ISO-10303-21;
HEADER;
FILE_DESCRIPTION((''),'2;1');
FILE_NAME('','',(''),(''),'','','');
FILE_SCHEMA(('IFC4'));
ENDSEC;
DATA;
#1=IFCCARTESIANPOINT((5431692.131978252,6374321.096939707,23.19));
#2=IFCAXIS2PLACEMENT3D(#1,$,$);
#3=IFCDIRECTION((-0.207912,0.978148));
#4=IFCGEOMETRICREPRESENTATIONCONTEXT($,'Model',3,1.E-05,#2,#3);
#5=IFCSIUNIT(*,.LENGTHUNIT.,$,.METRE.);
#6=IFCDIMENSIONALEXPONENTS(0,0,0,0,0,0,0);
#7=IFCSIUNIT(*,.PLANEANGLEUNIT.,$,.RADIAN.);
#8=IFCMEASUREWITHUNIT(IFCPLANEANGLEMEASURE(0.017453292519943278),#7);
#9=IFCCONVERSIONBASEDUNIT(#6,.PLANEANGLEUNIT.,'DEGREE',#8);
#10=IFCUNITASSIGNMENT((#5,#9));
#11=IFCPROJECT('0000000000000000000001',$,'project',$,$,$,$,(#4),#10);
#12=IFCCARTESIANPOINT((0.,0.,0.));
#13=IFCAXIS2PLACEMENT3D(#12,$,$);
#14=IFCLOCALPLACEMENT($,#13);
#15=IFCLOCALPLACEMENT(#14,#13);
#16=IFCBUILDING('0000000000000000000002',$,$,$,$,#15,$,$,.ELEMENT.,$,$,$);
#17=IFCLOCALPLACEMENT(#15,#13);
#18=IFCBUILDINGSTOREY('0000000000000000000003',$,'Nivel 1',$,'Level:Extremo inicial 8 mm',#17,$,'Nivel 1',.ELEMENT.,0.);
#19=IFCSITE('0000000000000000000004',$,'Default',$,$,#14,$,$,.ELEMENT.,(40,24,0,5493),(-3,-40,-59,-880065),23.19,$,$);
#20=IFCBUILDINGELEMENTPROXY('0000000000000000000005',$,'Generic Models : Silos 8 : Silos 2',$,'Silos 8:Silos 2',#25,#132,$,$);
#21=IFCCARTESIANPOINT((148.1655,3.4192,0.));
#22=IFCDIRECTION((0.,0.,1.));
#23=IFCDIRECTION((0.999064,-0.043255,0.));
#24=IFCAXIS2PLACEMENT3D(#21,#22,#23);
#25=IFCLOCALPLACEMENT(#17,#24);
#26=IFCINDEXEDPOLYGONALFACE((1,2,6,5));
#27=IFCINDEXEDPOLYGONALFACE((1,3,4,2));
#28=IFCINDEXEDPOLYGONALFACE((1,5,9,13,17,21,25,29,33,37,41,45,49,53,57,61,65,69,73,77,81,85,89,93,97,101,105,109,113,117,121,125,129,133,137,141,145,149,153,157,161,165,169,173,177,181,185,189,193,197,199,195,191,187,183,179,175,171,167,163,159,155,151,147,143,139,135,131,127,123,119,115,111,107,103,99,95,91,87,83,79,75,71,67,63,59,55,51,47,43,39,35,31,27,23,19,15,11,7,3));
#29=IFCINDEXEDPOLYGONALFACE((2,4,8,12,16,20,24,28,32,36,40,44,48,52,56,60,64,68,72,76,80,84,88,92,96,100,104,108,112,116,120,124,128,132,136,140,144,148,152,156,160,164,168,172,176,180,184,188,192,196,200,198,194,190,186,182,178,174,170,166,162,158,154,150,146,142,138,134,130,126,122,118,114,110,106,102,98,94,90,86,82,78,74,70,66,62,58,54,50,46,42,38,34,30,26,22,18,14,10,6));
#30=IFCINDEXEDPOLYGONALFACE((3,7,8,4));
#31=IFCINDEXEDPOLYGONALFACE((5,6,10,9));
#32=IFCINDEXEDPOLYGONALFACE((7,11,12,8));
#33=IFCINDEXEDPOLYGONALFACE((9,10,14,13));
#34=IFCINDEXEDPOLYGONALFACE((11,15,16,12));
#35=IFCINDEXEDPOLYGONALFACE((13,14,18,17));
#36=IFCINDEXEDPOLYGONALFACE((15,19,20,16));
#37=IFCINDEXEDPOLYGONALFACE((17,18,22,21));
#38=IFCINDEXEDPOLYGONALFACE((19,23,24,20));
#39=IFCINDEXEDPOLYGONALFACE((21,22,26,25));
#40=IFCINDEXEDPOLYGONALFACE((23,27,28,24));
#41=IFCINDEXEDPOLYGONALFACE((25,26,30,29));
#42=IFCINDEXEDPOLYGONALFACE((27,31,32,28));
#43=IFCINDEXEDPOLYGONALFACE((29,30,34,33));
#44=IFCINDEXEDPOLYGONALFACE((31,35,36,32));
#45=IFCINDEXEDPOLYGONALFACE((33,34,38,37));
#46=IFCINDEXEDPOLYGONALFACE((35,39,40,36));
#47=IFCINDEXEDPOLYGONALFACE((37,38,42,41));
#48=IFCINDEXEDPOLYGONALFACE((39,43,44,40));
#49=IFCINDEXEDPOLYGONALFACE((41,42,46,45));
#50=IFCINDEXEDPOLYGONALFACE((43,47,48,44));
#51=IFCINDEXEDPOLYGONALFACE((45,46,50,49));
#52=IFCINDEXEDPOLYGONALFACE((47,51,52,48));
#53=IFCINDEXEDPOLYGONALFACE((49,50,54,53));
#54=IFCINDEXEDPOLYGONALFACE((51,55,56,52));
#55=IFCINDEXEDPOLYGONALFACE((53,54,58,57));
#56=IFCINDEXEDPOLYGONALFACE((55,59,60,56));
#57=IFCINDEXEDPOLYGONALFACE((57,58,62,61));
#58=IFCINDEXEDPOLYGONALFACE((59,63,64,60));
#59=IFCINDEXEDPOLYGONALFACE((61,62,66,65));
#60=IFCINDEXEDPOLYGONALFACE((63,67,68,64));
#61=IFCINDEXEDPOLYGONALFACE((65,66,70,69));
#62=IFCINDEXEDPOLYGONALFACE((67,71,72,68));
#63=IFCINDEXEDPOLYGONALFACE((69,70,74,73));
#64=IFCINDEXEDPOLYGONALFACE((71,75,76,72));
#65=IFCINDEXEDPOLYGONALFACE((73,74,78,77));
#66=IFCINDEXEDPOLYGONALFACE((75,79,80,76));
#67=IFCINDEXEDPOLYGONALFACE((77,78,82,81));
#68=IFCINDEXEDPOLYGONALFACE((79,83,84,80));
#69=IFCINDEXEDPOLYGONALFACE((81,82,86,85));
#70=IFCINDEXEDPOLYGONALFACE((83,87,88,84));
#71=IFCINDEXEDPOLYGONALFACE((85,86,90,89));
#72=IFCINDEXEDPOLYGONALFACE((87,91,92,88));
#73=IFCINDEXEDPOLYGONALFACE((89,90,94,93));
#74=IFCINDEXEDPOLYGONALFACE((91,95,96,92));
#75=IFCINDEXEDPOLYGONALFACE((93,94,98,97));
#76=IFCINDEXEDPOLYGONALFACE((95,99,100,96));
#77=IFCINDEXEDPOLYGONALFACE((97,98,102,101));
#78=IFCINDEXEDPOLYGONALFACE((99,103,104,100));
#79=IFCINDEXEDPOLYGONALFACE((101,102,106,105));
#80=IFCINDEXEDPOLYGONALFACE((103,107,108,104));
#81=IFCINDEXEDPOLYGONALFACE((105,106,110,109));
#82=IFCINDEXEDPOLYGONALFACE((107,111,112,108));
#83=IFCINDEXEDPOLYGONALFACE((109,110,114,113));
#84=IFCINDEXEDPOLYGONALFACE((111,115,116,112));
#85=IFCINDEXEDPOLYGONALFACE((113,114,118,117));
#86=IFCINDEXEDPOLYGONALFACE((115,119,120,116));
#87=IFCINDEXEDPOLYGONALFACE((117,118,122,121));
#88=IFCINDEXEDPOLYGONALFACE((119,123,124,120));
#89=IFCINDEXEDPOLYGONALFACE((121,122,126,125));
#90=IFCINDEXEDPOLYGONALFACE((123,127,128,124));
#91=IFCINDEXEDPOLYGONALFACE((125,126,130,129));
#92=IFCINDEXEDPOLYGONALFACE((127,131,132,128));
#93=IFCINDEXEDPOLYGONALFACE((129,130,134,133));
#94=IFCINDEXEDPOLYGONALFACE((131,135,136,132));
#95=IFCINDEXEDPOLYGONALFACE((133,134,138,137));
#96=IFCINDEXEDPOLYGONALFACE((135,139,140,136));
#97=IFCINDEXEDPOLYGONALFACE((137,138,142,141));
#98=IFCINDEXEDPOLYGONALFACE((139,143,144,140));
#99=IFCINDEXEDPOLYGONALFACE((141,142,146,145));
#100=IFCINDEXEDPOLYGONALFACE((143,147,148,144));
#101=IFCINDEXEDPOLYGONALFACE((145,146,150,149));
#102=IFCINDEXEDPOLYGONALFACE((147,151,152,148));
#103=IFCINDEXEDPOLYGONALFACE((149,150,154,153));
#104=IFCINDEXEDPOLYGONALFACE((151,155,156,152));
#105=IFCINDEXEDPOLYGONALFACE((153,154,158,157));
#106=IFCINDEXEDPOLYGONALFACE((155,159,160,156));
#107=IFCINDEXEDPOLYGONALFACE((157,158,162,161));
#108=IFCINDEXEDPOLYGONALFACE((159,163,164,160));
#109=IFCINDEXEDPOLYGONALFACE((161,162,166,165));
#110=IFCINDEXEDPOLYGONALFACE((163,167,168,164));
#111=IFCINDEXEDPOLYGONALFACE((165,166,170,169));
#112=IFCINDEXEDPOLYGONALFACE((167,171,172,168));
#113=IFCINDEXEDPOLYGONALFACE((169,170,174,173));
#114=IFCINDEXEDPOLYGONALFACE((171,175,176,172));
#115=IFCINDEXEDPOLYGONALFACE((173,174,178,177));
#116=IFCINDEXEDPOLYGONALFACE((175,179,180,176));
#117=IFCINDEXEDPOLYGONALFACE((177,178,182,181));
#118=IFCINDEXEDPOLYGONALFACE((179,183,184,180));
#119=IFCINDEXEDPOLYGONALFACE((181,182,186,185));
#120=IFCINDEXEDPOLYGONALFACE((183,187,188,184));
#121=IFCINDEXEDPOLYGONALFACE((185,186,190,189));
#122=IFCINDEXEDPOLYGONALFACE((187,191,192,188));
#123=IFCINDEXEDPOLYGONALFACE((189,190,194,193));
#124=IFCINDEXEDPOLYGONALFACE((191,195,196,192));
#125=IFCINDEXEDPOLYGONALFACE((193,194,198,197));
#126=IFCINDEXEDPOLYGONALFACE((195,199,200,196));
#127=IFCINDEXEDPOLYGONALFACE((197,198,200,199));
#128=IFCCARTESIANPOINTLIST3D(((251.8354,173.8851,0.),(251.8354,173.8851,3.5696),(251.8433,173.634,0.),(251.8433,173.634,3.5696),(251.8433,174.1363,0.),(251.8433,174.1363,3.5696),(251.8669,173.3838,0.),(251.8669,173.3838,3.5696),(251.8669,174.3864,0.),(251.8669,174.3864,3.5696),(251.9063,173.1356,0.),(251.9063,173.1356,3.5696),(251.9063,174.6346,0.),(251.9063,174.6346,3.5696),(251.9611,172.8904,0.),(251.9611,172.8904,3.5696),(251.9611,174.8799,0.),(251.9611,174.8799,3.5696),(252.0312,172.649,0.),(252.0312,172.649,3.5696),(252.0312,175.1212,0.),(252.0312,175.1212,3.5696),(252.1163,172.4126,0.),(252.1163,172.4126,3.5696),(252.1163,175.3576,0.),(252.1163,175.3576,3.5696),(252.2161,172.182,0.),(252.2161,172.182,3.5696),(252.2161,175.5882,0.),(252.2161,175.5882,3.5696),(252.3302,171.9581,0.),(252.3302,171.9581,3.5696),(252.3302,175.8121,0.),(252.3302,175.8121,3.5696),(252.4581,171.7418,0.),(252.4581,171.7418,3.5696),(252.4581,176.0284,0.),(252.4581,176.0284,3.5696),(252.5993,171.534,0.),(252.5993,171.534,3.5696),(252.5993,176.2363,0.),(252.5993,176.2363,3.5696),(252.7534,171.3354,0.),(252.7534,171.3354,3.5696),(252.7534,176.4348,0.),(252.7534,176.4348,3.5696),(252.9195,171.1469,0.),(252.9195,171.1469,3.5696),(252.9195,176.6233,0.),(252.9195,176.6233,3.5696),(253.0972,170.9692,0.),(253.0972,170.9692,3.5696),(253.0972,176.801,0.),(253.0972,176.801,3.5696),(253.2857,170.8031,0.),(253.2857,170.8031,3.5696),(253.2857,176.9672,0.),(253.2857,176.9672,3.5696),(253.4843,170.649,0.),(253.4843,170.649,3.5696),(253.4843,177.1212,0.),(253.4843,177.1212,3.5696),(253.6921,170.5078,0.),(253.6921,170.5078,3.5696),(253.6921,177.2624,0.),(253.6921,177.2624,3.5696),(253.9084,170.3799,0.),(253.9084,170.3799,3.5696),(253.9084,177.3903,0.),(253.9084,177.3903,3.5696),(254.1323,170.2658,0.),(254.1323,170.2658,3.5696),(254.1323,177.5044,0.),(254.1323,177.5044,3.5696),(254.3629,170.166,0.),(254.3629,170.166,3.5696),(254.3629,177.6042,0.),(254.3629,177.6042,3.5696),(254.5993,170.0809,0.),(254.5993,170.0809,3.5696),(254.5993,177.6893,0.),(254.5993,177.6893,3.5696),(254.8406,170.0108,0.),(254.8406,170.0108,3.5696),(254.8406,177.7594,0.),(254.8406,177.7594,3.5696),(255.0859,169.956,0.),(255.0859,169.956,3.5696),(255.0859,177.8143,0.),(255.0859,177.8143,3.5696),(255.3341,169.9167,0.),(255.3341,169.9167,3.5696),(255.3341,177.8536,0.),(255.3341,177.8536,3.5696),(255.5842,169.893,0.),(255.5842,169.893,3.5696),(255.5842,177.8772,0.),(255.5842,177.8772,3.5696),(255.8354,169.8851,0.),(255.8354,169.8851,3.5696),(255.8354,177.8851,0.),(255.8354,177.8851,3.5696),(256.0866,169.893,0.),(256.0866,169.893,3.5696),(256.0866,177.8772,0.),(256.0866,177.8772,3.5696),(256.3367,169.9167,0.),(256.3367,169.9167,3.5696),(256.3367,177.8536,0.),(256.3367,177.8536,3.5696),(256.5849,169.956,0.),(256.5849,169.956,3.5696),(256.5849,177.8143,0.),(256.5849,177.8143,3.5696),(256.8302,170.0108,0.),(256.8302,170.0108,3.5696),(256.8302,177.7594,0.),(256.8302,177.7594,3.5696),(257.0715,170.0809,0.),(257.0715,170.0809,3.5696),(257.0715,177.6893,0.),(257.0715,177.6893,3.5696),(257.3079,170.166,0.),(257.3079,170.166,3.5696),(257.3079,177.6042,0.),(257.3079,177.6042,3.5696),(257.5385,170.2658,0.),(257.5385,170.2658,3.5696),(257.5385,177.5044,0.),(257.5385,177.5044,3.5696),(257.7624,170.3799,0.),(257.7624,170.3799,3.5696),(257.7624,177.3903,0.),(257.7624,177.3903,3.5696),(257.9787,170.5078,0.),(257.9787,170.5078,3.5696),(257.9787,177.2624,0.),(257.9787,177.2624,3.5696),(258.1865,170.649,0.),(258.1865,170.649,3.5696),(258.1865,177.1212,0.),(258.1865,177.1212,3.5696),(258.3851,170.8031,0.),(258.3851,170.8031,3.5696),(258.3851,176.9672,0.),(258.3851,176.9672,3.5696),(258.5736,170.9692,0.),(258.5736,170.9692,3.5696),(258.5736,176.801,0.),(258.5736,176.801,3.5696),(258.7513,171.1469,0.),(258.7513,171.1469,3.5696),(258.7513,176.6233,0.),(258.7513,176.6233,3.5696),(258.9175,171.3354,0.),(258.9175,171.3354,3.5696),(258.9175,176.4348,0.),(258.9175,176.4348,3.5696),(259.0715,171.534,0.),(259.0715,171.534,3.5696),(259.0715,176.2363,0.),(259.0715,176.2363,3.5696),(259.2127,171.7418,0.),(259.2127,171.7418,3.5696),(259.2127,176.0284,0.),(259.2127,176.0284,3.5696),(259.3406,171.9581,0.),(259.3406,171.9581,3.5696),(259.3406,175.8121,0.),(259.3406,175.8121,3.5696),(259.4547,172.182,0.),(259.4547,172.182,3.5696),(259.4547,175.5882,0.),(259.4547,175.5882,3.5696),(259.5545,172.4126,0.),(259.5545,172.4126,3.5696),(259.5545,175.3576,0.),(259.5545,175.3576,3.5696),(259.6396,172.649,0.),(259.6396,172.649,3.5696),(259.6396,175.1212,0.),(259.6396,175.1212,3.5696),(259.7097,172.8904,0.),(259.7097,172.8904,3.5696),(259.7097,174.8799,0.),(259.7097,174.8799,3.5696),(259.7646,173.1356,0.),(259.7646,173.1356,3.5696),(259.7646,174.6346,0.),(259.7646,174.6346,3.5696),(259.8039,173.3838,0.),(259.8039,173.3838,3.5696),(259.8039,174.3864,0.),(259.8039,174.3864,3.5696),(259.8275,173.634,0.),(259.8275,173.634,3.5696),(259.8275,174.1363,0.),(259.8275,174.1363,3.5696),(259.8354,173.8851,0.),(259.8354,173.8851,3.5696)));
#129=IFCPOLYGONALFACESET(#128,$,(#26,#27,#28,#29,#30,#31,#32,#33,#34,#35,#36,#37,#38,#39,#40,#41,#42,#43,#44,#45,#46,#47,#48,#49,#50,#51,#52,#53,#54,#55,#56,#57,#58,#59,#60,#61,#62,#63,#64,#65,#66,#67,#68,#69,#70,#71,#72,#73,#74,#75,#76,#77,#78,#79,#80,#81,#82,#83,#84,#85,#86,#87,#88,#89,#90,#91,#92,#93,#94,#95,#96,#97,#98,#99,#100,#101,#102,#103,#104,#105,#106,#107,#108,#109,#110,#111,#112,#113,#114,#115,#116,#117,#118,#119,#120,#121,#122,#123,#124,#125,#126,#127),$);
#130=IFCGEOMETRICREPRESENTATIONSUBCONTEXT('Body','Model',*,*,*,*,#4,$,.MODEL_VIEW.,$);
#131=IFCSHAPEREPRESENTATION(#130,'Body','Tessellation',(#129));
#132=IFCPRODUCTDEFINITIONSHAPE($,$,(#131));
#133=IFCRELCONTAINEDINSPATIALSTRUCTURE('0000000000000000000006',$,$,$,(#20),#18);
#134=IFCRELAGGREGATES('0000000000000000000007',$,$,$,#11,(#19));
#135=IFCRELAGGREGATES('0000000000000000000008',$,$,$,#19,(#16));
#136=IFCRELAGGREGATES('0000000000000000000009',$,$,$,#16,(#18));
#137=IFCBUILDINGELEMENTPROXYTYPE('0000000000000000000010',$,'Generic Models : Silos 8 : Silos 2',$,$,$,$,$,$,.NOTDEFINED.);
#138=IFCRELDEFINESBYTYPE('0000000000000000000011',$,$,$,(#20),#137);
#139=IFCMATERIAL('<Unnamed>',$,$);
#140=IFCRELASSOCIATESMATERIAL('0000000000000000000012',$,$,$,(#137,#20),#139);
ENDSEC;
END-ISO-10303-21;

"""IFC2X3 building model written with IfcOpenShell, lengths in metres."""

from ifc_helpers import new_model, entity, si_unit, converted_unit, direction, frame, origin, origin_2d_with_axis, place, context, subcontext, project, spatial, circle, extrude, source, transform, mapped, material, type_object, type_shapes, element, save


model = new_model("IFC2X3")

# Units and contexts
model_context = context("Model", 3, precision=1e-05, world=frame((5431692.131978252, 6374321.096939707, 23.19)), true_north=direction((-0.207912, 0.978148)))
body_context = subcontext(model_context, "Body", "Model", "MODEL_VIEW")
ifc_project = project(units=[si_unit("LENGTHUNIT", "METRE"), converted_unit("PLANEANGLEUNIT", "DEGREE", entity("IfcPlaneAngleMeasure", 0.017453292519943278), si_unit("PLANEANGLEUNIT", "RADIAN"), dimensions=[0, 0, 0, 0, 0, 0, 0])], contexts=[model_context])

# Site, building, storey
site_placement = place(None, origin())
site = spatial("IfcSite", under=ifc_project, at=site_placement, Name="Default", CompositionType="ELEMENT", RefLatitude=(40, 24, 0, 5493), RefLongitude=(-3, -40, -59, -880065), RefElevation=23.19)
building_placement = place(site_placement, origin())
building = spatial("IfcBuilding", under=site, at=building_placement, CompositionType="ELEMENT")
storey_placement = place(building_placement, origin())
storey = spatial("IfcBuildingStorey", under=building, at=storey_placement, Name="Nivel 1", ObjectType="Level:Extremo inicial 8 mm", LongName="Nivel 1", CompositionType="ELEMENT", Elevation=0.0)

# Building element proxy
ifc_material_1 = material(Name="<Unnamed>")
building_element_proxy_type_1 = type_object("IfcBuildingElementProxyType", Name="Generic Models : Silos 8 : Silos 2", PredefinedType="NOTDEFINED", material=ifc_material_1)
shared_shape_1 = source(origin(), body_context, "Body", "SweptSolid", [
    extrude(circle(Radius=4.0, at=origin_2d_with_axis()), frame((255.8354, 173.8851, 0.0)), (0.0, 0.0, 1.0), 3.5696),
])
type_shapes(building_element_proxy_type_1, [shared_shape_1])
proxy_1_placement = place(storey_placement, frame((148.1655, 3.4192, 0.0), z_axis=(0.0, 0.0, 1.0), x_axis=(0.999064, -0.043255, 0.0)))
element("IfcBuildingElementProxy", 1, at=proxy_1_placement, inside=storey, type_object=building_element_proxy_type_1, material=ifc_material_1, Name="Generic Models : Silos 8 : Silos 2", ObjectType="Silos 8:Silos 2", context=body_context, shape_type="MappedRepresentation", body=[
    mapped(shared_shape_1, transform((0.0, 0.0, 0.0), scale=1.0)),
])

save(model, "model.ifc")
